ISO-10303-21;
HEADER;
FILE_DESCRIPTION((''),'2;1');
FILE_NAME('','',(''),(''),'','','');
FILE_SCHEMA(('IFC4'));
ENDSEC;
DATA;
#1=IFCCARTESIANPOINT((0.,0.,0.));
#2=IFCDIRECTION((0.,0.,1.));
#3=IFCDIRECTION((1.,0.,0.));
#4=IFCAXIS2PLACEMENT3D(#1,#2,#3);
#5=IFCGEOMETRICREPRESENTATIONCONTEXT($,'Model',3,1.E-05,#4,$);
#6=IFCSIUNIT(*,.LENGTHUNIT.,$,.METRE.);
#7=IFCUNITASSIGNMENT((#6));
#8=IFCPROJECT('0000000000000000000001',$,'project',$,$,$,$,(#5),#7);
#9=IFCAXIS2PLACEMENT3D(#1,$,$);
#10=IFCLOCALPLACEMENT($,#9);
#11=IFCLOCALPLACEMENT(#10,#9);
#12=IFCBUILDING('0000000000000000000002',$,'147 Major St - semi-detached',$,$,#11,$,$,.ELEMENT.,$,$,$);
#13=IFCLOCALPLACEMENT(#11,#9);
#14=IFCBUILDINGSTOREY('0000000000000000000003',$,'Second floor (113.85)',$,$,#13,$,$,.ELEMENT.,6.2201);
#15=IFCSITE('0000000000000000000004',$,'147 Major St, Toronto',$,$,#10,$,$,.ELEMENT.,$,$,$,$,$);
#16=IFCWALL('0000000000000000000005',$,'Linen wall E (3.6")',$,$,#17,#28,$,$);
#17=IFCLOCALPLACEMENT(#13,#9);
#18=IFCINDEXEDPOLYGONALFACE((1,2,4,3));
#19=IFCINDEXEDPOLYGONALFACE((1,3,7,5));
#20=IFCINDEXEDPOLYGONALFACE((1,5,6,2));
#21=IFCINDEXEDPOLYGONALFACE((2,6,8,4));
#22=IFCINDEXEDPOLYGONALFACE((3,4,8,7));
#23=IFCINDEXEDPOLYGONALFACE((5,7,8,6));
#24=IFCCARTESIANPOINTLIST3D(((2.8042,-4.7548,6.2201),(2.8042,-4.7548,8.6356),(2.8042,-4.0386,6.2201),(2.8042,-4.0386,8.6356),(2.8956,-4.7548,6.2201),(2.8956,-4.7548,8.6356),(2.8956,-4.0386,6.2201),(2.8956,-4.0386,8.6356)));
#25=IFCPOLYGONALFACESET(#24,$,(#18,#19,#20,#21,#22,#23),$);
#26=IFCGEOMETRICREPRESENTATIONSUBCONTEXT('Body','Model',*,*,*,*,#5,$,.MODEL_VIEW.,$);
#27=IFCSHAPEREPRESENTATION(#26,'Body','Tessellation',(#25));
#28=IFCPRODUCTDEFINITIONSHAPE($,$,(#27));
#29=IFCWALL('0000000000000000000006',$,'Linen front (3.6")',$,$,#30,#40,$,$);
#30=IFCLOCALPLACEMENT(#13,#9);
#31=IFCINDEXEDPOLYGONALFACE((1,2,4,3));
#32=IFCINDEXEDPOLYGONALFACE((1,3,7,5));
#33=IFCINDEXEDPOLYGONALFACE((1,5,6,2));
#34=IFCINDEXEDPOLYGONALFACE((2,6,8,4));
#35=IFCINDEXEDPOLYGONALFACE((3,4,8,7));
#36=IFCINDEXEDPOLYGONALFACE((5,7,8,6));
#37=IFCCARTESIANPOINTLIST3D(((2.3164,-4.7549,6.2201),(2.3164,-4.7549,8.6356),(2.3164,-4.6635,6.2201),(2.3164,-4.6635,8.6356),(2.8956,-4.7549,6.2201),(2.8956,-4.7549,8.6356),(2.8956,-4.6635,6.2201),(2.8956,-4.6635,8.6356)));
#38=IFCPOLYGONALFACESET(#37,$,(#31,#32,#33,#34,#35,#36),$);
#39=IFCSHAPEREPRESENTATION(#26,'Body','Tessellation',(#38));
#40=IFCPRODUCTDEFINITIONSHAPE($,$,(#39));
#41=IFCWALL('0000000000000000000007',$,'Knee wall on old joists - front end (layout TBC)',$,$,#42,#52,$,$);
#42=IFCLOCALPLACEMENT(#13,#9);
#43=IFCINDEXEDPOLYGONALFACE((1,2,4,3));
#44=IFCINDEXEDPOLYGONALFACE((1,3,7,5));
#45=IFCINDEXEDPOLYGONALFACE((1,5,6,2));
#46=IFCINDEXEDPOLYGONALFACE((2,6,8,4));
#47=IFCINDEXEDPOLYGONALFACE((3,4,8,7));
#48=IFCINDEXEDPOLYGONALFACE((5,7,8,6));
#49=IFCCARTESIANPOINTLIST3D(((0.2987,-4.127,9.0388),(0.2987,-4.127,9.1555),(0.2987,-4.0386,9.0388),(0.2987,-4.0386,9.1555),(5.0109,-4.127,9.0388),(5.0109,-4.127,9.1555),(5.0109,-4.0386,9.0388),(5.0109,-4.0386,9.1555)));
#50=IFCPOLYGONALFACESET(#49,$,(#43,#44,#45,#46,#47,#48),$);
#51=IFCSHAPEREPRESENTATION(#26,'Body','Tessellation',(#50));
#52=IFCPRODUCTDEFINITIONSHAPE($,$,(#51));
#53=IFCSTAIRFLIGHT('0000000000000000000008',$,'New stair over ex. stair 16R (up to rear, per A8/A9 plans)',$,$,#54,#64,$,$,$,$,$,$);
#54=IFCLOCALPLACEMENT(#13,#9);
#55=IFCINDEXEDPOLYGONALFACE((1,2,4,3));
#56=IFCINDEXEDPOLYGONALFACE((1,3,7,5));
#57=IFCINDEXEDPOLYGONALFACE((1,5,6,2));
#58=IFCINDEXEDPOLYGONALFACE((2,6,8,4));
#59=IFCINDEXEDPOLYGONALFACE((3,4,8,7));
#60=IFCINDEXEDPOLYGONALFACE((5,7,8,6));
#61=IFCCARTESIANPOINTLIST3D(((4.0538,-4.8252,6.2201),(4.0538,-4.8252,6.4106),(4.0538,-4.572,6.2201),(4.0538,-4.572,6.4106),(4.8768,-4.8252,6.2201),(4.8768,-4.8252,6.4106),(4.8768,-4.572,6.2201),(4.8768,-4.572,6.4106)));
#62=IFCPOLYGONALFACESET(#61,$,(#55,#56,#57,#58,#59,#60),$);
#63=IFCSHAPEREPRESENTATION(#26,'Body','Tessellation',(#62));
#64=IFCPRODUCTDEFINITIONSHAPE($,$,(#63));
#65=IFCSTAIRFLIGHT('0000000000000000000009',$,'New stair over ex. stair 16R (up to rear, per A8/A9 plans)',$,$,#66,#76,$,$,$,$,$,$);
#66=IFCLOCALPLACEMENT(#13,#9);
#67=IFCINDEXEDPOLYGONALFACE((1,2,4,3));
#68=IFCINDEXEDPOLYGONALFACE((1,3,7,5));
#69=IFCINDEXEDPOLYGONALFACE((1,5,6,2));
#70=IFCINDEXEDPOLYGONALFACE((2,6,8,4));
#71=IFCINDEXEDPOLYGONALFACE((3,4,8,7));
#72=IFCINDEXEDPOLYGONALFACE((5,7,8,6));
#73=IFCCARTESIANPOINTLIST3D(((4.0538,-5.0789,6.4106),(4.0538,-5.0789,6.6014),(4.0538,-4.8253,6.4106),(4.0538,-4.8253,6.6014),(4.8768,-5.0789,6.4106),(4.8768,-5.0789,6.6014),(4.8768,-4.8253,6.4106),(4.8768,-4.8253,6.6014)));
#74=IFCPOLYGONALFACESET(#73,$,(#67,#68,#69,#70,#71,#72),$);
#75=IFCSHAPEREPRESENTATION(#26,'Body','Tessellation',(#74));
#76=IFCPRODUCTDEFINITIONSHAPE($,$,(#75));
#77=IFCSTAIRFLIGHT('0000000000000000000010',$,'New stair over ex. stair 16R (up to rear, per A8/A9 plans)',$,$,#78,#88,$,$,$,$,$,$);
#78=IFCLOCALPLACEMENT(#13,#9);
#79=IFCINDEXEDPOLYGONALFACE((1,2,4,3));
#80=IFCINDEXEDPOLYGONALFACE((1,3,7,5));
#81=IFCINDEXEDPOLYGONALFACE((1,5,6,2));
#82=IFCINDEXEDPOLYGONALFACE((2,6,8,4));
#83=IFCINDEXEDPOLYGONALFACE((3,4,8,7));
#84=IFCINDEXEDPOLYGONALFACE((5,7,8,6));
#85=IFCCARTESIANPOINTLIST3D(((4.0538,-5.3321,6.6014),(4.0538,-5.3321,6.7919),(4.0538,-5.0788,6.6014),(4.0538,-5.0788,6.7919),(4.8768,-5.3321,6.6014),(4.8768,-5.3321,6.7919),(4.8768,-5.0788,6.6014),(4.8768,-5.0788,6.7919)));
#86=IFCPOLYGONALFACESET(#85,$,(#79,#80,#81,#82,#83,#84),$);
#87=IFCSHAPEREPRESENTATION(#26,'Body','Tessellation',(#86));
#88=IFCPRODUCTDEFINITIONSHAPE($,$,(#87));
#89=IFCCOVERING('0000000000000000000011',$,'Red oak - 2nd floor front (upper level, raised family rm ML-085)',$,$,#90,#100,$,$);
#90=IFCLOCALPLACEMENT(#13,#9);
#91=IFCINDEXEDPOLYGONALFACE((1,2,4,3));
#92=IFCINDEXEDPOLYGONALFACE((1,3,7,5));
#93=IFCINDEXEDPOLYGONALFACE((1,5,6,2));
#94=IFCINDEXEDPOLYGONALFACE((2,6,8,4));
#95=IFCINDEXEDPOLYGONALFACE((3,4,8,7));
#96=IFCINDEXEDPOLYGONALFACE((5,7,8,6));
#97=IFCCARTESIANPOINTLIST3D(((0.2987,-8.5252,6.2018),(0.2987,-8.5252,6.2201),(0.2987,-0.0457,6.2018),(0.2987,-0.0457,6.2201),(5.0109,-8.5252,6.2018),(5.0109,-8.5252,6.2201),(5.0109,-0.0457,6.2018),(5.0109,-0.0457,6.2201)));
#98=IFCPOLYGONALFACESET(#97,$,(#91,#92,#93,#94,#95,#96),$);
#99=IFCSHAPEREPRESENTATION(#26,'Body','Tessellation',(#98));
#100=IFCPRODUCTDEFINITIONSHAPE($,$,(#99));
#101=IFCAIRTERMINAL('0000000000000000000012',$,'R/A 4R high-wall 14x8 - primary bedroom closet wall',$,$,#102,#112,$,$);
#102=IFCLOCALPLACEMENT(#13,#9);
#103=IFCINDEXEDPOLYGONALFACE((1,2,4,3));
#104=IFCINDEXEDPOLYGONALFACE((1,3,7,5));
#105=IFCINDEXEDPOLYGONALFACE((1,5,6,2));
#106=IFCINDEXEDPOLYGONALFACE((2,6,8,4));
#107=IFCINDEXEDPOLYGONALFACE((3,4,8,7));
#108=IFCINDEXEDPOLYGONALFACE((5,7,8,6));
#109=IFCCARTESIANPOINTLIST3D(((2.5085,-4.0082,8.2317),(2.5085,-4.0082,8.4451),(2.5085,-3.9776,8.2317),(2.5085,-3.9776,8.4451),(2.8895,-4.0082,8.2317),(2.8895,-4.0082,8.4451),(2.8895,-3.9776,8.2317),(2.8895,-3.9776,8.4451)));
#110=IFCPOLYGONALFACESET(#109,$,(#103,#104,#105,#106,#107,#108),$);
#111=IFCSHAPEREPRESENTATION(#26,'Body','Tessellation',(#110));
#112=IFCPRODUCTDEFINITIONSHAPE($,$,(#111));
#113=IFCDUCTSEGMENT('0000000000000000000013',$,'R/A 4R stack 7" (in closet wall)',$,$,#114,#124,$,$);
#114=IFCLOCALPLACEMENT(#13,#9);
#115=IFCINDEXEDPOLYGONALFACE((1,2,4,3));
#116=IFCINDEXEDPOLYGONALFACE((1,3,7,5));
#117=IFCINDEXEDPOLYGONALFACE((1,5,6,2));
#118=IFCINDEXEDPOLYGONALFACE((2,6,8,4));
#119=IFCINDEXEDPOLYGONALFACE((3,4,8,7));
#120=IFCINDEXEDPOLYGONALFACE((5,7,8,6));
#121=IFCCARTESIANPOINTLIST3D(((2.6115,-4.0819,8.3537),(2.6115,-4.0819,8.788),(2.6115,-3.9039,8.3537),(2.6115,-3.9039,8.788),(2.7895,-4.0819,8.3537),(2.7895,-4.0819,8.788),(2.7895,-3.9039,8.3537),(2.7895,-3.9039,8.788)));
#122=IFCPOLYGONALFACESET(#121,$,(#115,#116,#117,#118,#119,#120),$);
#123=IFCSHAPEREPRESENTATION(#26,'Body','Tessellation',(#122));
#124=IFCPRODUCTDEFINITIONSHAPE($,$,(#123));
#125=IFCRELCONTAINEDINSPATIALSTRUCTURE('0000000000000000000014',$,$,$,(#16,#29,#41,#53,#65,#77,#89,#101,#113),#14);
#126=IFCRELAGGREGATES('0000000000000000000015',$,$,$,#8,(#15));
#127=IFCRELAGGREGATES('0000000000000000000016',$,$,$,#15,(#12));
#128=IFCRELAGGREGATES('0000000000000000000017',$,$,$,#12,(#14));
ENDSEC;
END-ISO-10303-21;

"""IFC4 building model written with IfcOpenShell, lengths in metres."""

from ifc_helpers import new_model, si_unit, frame, origin, origin_with_axes, place, context, subcontext, project, spatial, rectangle, extrude, element, save


model = new_model("IFC4")

# Units and contexts
model_context = context("Model", 3, precision=1e-05, world=origin_with_axes())
body_context = subcontext(model_context, "Body", "Model", "MODEL_VIEW")
ifc_project = project(units=[si_unit("LENGTHUNIT", "METRE")], contexts=[model_context])

# Site, building, storey
site_placement = place(None, origin())
site = spatial("IfcSite", under=ifc_project, at=site_placement, Name="147 Major St, Toronto", CompositionType="ELEMENT")
building_placement = place(site_placement, origin())
building = spatial("IfcBuilding", under=site, at=building_placement, Name="147 Major St - semi-detached", CompositionType="ELEMENT")
storey_placement = place(building_placement, origin())
storey = spatial("IfcBuildingStorey", under=building, at=storey_placement, Name="Second floor (113.85)", CompositionType="ELEMENT", Elevation=6.2201)

# Walls
for number, where, name in (
    (1, (2.8499, -4.3967, 6.2201), "Linen wall E (3.6\")"),
):
    element("IfcWall", number, at=place(storey_placement, frame(where)), inside=storey, Name=name, context=body_context, shape_type="SweptSolid", body=[
        extrude(rectangle(XDim=0.0914, YDim=0.7163), origin_with_axes(), (0.0, 0.0, 1.0), 2.4155),
    ])
wall_1_placement = place(storey_placement, frame((2.606, -4.7092, 6.2201)))
element("IfcWall", 2, at=wall_1_placement, inside=storey, Name="Linen front (3.6\")", context=body_context, shape_type="SweptSolid", body=[
    extrude(rectangle(XDim=0.5791, YDim=0.0914), origin_with_axes(), (0.0, 0.0, 1.0), 2.4155),
])
wall_2_placement = place(storey_placement, frame((2.6548, -4.0828, 9.0388)))
element("IfcWall", 3, at=wall_2_placement, inside=storey, Name="Knee wall on old joists - front end (layout TBC)", context=body_context, shape_type="SweptSolid", body=[
    extrude(rectangle(XDim=4.7122, YDim=0.0884), origin_with_axes(), (0.0, 0.0, 1.0), 0.1167),
])

# Stair flights
stair_flight_1_placement = place(storey_placement, frame((4.4653, -4.6986, 6.2201)))
element("IfcStairFlight", 4, at=stair_flight_1_placement, inside=storey, Name="New stair over ex. stair 16R (up to rear, per A8/A9 plans)", context=body_context, shape_type="SweptSolid", body=[
    extrude(rectangle(XDim=0.823, YDim=0.2533), origin_with_axes(), (0.0, 0.0, 1.0), 0.1905),
])
stair_flight_2_placement = place(storey_placement, frame((4.4653, -4.9521, 6.4106)))
element("IfcStairFlight", 5, at=stair_flight_2_placement, inside=storey, Name="New stair over ex. stair 16R (up to rear, per A8/A9 plans)", context=body_context, shape_type="SweptSolid", body=[
    extrude(rectangle(XDim=0.823, YDim=0.2536), origin_with_axes(), (0.0, 0.0, 1.0), 0.1908),
])
stair_flight_3_placement = place(storey_placement, frame((4.4653, -5.2055, 6.6014)))
element("IfcStairFlight", 6, at=stair_flight_3_placement, inside=storey, Name="New stair over ex. stair 16R (up to rear, per A8/A9 plans)", context=body_context, shape_type="SweptSolid", body=[
    extrude(rectangle(XDim=0.823, YDim=0.2533), origin_with_axes(), (0.0, 0.0, 1.0), 0.1905),
])

# Covering
covering_placement = place(storey_placement, frame((2.6548, -4.2855, 6.2018)))
element("IfcCovering", 7, at=covering_placement, inside=storey, Name="Red oak - 2nd floor front (upper level, raised family rm ML-085)", context=body_context, shape_type="SweptSolid", body=[
    extrude(rectangle(XDim=4.7122, YDim=8.4795), origin_with_axes(), (0.0, 0.0, 1.0), 0.0183),
])

# Air terminal
air_terminal_placement = place(storey_placement, frame((2.699, -3.9929, 8.2317)))
element("IfcAirTerminal", 8, at=air_terminal_placement, inside=storey, Name="R/A 4R high-wall 14x8 - primary bedroom closet wall", context=body_context, shape_type="SweptSolid", body=[
    extrude(rectangle(XDim=0.381, YDim=0.0305), origin_with_axes(), (0.0, 0.0, 1.0), 0.2134),
])

# Duct segment
duct_segment_placement = place(storey_placement, frame((2.7005, -3.9929, 8.3537)))
element("IfcDuctSegment", 9, at=duct_segment_placement, inside=storey, Name="R/A 4R stack 7\" (in closet wall)", context=body_context, shape_type="SweptSolid", body=[
    extrude(rectangle(XDim=0.178, YDim=0.178), origin_with_axes(), (0.0, 0.0, 1.0), 0.4343),
])

save(model, "model.ifc")
